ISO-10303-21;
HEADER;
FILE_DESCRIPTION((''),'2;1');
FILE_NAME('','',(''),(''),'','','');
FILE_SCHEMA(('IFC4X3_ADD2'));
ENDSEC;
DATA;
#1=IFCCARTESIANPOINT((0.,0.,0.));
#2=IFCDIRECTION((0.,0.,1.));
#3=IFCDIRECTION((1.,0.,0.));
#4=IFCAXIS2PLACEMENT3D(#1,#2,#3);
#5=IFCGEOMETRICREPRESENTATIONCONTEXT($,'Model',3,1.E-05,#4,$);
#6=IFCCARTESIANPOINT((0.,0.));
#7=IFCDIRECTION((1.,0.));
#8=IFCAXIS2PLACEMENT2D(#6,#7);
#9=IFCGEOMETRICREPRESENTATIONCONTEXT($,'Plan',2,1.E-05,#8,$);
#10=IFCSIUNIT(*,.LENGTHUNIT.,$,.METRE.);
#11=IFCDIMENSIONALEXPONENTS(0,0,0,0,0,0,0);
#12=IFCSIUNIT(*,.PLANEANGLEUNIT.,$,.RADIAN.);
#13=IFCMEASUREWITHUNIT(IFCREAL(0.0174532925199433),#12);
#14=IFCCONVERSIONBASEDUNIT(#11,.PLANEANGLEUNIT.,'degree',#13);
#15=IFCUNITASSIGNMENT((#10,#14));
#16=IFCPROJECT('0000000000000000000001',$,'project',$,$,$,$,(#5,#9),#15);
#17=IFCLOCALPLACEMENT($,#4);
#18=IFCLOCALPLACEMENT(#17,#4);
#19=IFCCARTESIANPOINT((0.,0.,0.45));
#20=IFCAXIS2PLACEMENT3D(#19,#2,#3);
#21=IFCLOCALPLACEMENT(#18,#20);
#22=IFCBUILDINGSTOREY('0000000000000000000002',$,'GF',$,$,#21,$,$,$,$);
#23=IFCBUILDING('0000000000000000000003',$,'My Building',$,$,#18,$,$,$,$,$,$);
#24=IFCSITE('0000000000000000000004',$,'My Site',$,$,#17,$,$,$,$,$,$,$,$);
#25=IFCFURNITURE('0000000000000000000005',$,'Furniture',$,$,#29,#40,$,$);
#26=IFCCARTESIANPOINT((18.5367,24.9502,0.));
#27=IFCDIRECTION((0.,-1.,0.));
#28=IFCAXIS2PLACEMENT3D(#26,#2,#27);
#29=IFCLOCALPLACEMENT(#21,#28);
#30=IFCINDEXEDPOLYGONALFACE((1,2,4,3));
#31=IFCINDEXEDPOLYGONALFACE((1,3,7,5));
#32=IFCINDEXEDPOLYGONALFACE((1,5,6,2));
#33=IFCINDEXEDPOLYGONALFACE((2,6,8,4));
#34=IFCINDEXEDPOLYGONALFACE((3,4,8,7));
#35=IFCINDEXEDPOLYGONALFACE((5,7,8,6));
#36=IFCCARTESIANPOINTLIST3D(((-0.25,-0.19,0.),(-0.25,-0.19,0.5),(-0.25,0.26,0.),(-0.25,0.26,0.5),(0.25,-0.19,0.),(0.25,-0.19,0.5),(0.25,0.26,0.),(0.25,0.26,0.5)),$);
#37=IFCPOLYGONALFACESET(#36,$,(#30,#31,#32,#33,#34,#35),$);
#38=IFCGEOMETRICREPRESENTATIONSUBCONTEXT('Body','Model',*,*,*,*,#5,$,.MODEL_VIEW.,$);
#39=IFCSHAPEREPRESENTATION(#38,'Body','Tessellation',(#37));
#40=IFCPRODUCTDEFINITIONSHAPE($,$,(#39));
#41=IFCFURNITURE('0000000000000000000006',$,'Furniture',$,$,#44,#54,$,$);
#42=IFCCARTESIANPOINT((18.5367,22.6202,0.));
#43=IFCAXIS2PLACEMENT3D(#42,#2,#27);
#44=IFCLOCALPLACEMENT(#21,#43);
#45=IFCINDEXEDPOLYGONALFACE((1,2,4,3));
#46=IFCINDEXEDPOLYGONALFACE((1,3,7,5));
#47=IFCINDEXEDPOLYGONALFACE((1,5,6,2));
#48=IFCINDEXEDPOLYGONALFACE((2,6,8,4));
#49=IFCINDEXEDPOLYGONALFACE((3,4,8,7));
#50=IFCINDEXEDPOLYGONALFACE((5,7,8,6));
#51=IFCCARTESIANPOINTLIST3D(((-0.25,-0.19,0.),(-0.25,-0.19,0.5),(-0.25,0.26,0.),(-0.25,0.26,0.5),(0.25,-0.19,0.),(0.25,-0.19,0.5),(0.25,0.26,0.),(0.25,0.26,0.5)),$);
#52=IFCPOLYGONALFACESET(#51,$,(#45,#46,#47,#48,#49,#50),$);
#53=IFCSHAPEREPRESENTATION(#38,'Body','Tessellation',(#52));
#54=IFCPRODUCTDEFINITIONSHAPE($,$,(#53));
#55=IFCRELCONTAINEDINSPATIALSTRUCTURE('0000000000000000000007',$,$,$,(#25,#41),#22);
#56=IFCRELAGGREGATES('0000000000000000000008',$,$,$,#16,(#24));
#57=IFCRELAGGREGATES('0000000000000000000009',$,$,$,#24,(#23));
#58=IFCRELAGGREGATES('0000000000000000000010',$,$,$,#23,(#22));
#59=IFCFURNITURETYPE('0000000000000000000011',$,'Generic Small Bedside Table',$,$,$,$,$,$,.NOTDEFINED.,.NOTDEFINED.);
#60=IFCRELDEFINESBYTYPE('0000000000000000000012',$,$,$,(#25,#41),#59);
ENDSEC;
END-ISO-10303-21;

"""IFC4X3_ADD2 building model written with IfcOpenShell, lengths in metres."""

from ifc_helpers import new_model, entity, si_unit, converted_unit, frame, origin_with_axes, origin_2d_with_axis, place, context, subcontext, project, spatial, line, indexed_curve, outline, extrude, shape, source, transform, mapped, type_object, type_shapes, element, save


model = new_model("IFC4X3_ADD2")

# Units and contexts
model_context = context("Model", 3, precision=1e-05, world=origin_with_axes())
plan_context = context("Plan", 2, precision=1e-05, world=origin_2d_with_axis())
body_context_1 = subcontext(model_context, "Body", "Model", "MODEL_VIEW")
body_context_2 = subcontext(plan_context, "Body", "Plan", "PLAN_VIEW")
ifc_project = project(units=[si_unit("LENGTHUNIT", "METRE"), converted_unit("PLANEANGLEUNIT", "degree", entity("IfcReal", 0.0174532925199433), si_unit("PLANEANGLEUNIT", "RADIAN"), dimensions=[0, 0, 0, 0, 0, 0, 0])], contexts=[model_context, plan_context])

# Site, building, storey
site_placement = place(None, origin_with_axes())
site = spatial("IfcSite", under=ifc_project, at=site_placement, Name="My Site")
building_placement = place(site_placement, origin_with_axes())
building = spatial("IfcBuilding", under=site, at=building_placement, Name="My Building")
storey_placement = place(building_placement, frame((0.0, 0.0, 0.45), z_axis=(0.0, 0.0, 1.0), x_axis=(1.0, 0.0, 0.0)))
storey = spatial("IfcBuildingStorey", under=building, at=storey_placement, Name="GF")

# Furniture
furniture_type_1 = type_object("IfcFurnitureType", Name="Generic Small Bedside Table", AssemblyPlace="NOTDEFINED", PredefinedType="NOTDEFINED")
shared_shape_1 = source(origin_with_axes(), body_context_1, "Body", "SweptSolid", [
    extrude(outline(indexed_curve([(0.5, 0.45), (0.5, 0.0), (0.0, 0.0), (0.0, 0.45)], segments=[line(4, 1), line(1, 2), line(2, 3), line(3, 4)], self_intersect=False)), frame((-0.25, -0.19, 0.0), z_axis=(0.0, 0.0, 1.0), x_axis=(1.0, 0.0, 0.0)), (0.0, 0.0, 1.0), 0.5),
])
shared_shape_2 = source(origin_with_axes(), body_context_2, "Body", "Annotation2D", [
    entity("IfcGeometricCurveSet", [entity("IfcIndexedPolyCurve", entity("IfcCartesianPointList2D", [[-0.25, -0.19], [0.25, -0.19], [0.25, 0.26], [-0.25, 0.26]]), [entity("IfcLineIndex", [1, 2]), entity("IfcLineIndex", [2, 3]), entity("IfcLineIndex", [3, 4]), entity("IfcLineIndex", [4, 1])])]),
])
type_shapes(furniture_type_1, [shared_shape_1, shared_shape_2])
for number, where, z_axis, x_axis, name in (
    (1, (18.5367, 24.9502, 0.0), (0.0, 0.0, 1.0), (0.0, -1.0, 0.0), "Furniture"),
    (2, (18.5367, 22.6202, 0.0), (0.0, 0.0, 1.0), (0.0, -1.0, 0.0), "Furniture"),
):
    element("IfcFurniture", number, at=place(storey_placement, frame(where, z_axis=z_axis, x_axis=x_axis)), inside=storey, type_object=furniture_type_1, Name=name, shapes=[
        shape(body_context_1, "Body", "MappedRepresentation", [mapped(shared_shape_1, transform((0.0, 0.0, 0.0), x_axis=(1.0, 0.0, 0.0), y_axis=(0.0, 1.0, 0.0), z_axis=(0.0, 0.0, 1.0), scale=1.0))]),
        shape(body_context_2, "Body", "MappedRepresentation", [mapped(shared_shape_2, transform((0.0, 0.0, 0.0), x_axis=(1.0, 0.0, 0.0), y_axis=(0.0, 1.0, 0.0), z_axis=(0.0, 0.0, 1.0), scale=1.0))]),
    ])

save(model, "model.ifc")
